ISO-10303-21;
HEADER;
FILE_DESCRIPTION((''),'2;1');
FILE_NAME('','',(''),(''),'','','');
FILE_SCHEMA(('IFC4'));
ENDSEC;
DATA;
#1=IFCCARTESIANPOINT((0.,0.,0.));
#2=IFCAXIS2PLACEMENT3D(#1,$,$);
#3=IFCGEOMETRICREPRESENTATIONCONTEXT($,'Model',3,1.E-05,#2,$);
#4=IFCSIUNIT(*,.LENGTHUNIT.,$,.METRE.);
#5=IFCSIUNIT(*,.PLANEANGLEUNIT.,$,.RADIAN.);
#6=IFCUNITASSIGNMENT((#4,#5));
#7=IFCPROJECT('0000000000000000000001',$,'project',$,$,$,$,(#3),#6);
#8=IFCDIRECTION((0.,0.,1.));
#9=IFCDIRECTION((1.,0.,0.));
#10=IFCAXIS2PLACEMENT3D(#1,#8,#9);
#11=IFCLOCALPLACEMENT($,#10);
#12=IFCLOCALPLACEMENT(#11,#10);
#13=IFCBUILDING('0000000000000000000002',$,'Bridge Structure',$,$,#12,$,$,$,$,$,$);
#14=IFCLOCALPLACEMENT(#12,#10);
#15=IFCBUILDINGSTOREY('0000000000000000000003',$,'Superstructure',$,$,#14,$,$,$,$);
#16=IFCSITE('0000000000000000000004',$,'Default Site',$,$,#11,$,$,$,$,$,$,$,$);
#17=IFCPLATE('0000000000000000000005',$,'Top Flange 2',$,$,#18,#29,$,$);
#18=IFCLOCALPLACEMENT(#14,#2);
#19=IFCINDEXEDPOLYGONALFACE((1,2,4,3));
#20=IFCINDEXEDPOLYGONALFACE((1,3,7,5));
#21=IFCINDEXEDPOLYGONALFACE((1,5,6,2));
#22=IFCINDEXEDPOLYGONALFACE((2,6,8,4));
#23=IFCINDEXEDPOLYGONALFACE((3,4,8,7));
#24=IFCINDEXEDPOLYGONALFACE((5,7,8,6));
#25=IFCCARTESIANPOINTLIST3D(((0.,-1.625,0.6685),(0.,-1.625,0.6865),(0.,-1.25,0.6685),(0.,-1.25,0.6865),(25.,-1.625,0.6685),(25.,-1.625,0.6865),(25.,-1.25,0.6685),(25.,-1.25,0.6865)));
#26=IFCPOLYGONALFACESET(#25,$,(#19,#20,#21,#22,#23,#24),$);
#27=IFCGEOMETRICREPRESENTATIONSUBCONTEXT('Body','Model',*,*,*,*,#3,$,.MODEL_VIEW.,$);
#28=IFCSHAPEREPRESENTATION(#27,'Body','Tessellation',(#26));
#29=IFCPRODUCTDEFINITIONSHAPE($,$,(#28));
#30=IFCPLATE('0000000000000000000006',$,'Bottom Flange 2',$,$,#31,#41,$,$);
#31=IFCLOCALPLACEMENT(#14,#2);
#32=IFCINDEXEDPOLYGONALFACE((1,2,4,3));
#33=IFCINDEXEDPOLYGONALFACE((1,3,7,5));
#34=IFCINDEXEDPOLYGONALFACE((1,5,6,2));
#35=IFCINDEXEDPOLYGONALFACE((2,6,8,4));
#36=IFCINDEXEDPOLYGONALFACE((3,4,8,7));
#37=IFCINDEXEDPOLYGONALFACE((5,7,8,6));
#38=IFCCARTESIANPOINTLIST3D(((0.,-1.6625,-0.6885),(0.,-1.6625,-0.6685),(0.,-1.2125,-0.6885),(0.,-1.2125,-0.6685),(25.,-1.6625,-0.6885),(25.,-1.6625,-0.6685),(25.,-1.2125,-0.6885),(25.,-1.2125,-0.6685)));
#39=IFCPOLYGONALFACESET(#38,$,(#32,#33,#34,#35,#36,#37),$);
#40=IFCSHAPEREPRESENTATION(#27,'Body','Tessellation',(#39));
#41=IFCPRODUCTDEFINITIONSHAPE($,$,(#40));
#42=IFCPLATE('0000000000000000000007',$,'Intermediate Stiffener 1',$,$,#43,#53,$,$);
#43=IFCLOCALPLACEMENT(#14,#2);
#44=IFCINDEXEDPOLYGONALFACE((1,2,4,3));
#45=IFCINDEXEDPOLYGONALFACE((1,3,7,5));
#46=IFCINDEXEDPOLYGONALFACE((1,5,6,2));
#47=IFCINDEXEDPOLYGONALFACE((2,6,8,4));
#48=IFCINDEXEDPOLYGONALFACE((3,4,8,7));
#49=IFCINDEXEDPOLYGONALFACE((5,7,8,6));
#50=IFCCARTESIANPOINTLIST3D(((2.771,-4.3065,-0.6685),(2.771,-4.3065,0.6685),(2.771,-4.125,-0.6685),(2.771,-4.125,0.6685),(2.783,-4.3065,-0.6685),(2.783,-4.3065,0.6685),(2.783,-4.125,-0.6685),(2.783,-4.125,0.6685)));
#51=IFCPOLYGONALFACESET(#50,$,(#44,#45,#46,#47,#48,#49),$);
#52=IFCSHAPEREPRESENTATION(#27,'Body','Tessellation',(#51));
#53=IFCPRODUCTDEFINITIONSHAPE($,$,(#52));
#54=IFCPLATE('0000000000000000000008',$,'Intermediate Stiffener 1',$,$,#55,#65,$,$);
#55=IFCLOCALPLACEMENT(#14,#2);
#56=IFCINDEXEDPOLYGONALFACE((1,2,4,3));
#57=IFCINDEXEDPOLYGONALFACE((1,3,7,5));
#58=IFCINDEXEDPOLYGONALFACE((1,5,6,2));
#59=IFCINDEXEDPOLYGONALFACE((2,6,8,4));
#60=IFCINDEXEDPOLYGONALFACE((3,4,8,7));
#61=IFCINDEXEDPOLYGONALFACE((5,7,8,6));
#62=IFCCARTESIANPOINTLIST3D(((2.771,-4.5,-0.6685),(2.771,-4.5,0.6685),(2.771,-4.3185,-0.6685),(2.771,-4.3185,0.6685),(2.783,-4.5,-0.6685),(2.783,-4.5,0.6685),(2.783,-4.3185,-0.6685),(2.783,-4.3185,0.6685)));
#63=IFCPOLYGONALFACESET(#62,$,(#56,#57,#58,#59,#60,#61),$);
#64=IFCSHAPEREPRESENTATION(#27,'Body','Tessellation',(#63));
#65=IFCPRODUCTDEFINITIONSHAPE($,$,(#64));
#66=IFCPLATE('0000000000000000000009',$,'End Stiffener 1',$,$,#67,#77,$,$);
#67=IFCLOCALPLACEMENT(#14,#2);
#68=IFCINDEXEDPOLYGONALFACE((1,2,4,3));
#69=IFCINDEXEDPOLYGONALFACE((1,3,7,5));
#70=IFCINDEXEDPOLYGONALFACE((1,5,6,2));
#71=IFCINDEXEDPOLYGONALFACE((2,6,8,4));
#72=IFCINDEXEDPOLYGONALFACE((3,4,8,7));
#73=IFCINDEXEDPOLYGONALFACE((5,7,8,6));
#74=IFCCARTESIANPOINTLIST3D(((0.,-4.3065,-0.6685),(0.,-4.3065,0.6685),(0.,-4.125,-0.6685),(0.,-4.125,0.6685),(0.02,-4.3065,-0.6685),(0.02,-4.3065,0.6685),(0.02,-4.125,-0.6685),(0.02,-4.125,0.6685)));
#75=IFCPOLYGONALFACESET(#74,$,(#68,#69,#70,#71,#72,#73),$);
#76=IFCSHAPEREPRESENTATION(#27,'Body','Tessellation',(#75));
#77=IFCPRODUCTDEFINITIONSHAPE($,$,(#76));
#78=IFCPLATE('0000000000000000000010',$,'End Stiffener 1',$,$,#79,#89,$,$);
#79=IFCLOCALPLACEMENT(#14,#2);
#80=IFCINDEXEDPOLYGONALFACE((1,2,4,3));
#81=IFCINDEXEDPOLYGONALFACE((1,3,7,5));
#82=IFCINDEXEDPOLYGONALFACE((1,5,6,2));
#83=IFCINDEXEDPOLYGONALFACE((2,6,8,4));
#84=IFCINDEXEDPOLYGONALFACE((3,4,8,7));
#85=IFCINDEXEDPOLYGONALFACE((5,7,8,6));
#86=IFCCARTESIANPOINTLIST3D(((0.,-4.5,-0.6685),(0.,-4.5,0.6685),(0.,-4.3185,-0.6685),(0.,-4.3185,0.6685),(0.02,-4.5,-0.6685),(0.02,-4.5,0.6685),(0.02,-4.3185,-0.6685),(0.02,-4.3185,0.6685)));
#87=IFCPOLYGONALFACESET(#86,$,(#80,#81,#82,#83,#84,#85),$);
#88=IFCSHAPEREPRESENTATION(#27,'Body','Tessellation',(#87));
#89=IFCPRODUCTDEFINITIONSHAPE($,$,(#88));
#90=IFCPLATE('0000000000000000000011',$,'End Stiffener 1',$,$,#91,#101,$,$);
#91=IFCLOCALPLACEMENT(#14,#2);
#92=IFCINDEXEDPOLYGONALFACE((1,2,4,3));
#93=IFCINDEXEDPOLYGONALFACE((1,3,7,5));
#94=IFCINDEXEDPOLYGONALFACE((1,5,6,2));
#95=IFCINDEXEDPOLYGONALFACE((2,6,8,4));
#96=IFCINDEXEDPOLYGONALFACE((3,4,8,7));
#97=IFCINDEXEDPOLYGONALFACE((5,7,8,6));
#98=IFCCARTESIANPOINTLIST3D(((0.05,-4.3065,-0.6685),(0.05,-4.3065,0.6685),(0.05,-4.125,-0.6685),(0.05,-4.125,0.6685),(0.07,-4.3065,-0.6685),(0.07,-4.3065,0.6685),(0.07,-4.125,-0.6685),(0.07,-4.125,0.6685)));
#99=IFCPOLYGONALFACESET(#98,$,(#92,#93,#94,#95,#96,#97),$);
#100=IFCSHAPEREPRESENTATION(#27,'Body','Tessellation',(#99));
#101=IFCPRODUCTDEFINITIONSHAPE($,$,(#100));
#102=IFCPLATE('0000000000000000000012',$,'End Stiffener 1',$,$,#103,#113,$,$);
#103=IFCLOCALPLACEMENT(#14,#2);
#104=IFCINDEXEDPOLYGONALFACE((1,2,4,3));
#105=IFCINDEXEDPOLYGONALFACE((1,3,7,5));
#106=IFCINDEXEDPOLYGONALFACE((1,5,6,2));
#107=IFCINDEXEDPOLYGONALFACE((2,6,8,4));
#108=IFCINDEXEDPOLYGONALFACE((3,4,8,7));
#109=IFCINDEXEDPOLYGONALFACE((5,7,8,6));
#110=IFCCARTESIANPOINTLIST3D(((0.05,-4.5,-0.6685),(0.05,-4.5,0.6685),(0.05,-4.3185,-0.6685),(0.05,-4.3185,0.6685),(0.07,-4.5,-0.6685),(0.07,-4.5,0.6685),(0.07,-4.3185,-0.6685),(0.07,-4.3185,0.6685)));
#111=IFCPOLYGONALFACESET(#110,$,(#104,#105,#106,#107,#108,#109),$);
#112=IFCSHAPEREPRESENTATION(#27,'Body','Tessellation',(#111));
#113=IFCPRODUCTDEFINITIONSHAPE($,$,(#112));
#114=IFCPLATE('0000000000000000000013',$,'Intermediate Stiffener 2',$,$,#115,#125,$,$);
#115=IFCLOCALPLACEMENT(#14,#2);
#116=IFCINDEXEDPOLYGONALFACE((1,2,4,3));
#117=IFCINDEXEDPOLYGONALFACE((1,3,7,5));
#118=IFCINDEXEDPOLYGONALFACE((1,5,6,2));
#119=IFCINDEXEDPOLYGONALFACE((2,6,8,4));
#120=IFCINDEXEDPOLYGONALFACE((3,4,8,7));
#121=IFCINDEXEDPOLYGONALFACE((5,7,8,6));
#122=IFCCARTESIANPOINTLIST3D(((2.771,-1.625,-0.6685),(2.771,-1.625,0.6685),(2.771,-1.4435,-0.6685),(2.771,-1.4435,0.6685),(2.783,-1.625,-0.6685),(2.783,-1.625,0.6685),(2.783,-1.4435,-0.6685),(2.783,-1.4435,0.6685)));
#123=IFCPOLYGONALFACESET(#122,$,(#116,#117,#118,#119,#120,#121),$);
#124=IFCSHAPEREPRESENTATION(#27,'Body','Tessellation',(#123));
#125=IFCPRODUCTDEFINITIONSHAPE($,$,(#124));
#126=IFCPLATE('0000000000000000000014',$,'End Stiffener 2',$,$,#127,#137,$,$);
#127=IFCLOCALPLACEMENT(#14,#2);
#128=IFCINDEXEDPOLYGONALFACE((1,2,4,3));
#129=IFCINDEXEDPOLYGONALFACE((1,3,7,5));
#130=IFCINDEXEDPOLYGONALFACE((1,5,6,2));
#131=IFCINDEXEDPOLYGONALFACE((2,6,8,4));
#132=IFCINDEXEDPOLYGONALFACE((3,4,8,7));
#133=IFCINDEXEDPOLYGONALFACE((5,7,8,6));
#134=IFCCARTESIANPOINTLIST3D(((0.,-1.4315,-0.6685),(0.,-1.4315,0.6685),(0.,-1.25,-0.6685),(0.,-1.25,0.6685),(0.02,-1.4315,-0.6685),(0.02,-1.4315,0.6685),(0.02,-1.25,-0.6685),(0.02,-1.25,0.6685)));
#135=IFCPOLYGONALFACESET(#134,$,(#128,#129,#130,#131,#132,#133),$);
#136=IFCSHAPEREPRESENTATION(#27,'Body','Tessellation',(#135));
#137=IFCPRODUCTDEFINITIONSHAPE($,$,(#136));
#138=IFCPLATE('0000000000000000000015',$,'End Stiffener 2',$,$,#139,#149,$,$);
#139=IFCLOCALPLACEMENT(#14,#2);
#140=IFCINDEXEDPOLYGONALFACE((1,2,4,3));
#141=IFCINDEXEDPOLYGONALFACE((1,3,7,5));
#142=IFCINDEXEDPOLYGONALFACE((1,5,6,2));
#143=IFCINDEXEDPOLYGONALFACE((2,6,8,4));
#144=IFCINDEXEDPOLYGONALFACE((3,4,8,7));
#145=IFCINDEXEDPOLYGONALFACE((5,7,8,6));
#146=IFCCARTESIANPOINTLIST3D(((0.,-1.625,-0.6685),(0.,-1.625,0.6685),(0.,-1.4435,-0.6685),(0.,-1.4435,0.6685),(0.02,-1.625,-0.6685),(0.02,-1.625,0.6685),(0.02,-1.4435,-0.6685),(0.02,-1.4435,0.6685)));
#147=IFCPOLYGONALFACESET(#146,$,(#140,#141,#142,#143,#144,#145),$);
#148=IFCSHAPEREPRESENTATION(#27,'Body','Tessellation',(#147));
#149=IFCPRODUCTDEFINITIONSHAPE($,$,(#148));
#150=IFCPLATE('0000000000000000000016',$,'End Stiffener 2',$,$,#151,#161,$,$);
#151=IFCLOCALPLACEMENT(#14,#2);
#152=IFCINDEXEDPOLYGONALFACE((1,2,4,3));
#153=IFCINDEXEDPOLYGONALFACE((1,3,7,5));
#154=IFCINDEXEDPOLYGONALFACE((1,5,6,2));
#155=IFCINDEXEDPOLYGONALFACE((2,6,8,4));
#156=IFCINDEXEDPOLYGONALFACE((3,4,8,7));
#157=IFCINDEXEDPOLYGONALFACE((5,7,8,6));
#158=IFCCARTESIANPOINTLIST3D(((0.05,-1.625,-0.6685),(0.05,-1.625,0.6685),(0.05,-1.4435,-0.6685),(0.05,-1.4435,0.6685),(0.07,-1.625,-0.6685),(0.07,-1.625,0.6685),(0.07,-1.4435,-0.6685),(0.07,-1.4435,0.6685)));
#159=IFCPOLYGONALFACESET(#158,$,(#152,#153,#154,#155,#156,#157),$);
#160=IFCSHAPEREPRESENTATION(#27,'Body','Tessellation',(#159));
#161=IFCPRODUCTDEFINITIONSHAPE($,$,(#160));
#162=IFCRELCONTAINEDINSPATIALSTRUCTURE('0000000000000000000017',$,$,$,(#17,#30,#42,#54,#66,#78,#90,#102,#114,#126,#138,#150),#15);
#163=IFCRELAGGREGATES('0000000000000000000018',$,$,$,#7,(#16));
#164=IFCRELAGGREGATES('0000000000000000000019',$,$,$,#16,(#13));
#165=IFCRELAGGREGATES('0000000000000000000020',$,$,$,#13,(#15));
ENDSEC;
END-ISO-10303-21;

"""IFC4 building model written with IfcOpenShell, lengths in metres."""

from ifc_helpers import new_model, si_unit, frame, origin, origin_with_axes, origin_2d_with_axis, place, context, subcontext, project, spatial, rectangle, extrude, element, save


model = new_model("IFC4")

# Units and contexts
model_context = context("Model", 3, precision=1e-05, world=origin())
body_context = subcontext(model_context, "Body", "Model", "MODEL_VIEW")
ifc_project = project(units=[si_unit("LENGTHUNIT", "METRE"), si_unit("PLANEANGLEUNIT", "RADIAN")], contexts=[model_context])

# Site, building, storey
site_placement = place(None, origin_with_axes())
site = spatial("IfcSite", under=ifc_project, at=site_placement, Name="Default Site")
building_placement = place(site_placement, origin_with_axes())
building = spatial("IfcBuilding", under=site, at=building_placement, Name="Bridge Structure")
storey_placement = place(building_placement, origin_with_axes())
storey = spatial("IfcBuildingStorey", under=building, at=storey_placement, Name="Superstructure")

# Plates
plate_1_placement = place(storey_placement, frame((0.0, -1.4375, 0.6775), z_axis=(1.0, 0.0, 0.0), x_axis=(0.0, 1.0, 0.0)))
element("IfcPlate", 1, at=plate_1_placement, inside=storey, Name="Top Flange 2", context=body_context, shape_type="SweptSolid", body=[
    extrude(rectangle(XDim=0.375, YDim=0.018, at=origin_2d_with_axis()), origin_with_axes(), (0.0, 0.0, 1.0), 25.0),
])
plate_2_placement = place(storey_placement, frame((0.0, -1.4375, -0.6785), z_axis=(1.0, 0.0, 0.0), x_axis=(0.0, 1.0, 0.0)))
element("IfcPlate", 2, at=plate_2_placement, inside=storey, Name="Bottom Flange 2", context=body_context, shape_type="SweptSolid", body=[
    extrude(rectangle(XDim=0.45, YDim=0.02, at=origin_2d_with_axis()), origin_with_axes(), (0.0, 0.0, 1.0), 25.0),
])
for number, where, z_axis, x_axis, name in (
    (3, (2.777, -4.2157, -0.6685), (0.0, 0.0, 1.0), (1.0, 0.0, 0.0), "Intermediate Stiffener 1"),
    (4, (2.777, -4.4093, -0.6685), (0.0, 0.0, 1.0), (1.0, 0.0, 0.0), "Intermediate Stiffener 1"),
):
    element("IfcPlate", number, at=place(storey_placement, frame(where, z_axis=z_axis, x_axis=x_axis)), inside=storey, Name=name, context=body_context, shape_type="SweptSolid", body=[
        extrude(rectangle(XDim=0.012, YDim=0.1815, at=origin_2d_with_axis()), origin_with_axes(), (0.0, 0.0, 1.0), 1.337),
    ])
for number, where, z_axis, x_axis, name in (
    (5, (0.01, -4.2157, -0.6685), (0.0, 0.0, 1.0), (1.0, 0.0, 0.0), "End Stiffener 1"),
    (6, (0.01, -4.4093, -0.6685), (0.0, 0.0, 1.0), (1.0, 0.0, 0.0), "End Stiffener 1"),
    (7, (0.06, -4.2157, -0.6685), (0.0, 0.0, 1.0), (1.0, 0.0, 0.0), "End Stiffener 1"),
    (8, (0.06, -4.4093, -0.6685), (0.0, 0.0, 1.0), (1.0, 0.0, 0.0), "End Stiffener 1"),
):
    element("IfcPlate", number, at=place(storey_placement, frame(where, z_axis=z_axis, x_axis=x_axis)), inside=storey, Name=name, context=body_context, shape_type="SweptSolid", body=[
        extrude(rectangle(XDim=0.02, YDim=0.1815, at=origin_2d_with_axis()), origin_with_axes(), (0.0, 0.0, 1.0), 1.337),
    ])
plate_3_placement = place(storey_placement, frame((2.777, -1.5343, -0.6685), z_axis=(0.0, 0.0, 1.0), x_axis=(1.0, 0.0, 0.0)))
element("IfcPlate", 9, at=plate_3_placement, inside=storey, Name="Intermediate Stiffener 2", context=body_context, shape_type="SweptSolid", body=[
    extrude(rectangle(XDim=0.012, YDim=0.1815, at=origin_2d_with_axis()), origin_with_axes(), (0.0, 0.0, 1.0), 1.337),
])
for number, where, z_axis, x_axis, name in (
    (10, (0.01, -1.3408, -0.6685), (0.0, 0.0, 1.0), (1.0, 0.0, 0.0), "End Stiffener 2"),
    (11, (0.01, -1.5343, -0.6685), (0.0, 0.0, 1.0), (1.0, 0.0, 0.0), "End Stiffener 2"),
    (12, (0.06, -1.5343, -0.6685), (0.0, 0.0, 1.0), (1.0, 0.0, 0.0), "End Stiffener 2"),
):
    element("IfcPlate", number, at=place(storey_placement, frame(where, z_axis=z_axis, x_axis=x_axis)), inside=storey, Name=name, context=body_context, shape_type="SweptSolid", body=[
        extrude(rectangle(XDim=0.02, YDim=0.1815, at=origin_2d_with_axis()), origin_with_axes(), (0.0, 0.0, 1.0), 1.337),
    ])

save(model, "model.ifc")
